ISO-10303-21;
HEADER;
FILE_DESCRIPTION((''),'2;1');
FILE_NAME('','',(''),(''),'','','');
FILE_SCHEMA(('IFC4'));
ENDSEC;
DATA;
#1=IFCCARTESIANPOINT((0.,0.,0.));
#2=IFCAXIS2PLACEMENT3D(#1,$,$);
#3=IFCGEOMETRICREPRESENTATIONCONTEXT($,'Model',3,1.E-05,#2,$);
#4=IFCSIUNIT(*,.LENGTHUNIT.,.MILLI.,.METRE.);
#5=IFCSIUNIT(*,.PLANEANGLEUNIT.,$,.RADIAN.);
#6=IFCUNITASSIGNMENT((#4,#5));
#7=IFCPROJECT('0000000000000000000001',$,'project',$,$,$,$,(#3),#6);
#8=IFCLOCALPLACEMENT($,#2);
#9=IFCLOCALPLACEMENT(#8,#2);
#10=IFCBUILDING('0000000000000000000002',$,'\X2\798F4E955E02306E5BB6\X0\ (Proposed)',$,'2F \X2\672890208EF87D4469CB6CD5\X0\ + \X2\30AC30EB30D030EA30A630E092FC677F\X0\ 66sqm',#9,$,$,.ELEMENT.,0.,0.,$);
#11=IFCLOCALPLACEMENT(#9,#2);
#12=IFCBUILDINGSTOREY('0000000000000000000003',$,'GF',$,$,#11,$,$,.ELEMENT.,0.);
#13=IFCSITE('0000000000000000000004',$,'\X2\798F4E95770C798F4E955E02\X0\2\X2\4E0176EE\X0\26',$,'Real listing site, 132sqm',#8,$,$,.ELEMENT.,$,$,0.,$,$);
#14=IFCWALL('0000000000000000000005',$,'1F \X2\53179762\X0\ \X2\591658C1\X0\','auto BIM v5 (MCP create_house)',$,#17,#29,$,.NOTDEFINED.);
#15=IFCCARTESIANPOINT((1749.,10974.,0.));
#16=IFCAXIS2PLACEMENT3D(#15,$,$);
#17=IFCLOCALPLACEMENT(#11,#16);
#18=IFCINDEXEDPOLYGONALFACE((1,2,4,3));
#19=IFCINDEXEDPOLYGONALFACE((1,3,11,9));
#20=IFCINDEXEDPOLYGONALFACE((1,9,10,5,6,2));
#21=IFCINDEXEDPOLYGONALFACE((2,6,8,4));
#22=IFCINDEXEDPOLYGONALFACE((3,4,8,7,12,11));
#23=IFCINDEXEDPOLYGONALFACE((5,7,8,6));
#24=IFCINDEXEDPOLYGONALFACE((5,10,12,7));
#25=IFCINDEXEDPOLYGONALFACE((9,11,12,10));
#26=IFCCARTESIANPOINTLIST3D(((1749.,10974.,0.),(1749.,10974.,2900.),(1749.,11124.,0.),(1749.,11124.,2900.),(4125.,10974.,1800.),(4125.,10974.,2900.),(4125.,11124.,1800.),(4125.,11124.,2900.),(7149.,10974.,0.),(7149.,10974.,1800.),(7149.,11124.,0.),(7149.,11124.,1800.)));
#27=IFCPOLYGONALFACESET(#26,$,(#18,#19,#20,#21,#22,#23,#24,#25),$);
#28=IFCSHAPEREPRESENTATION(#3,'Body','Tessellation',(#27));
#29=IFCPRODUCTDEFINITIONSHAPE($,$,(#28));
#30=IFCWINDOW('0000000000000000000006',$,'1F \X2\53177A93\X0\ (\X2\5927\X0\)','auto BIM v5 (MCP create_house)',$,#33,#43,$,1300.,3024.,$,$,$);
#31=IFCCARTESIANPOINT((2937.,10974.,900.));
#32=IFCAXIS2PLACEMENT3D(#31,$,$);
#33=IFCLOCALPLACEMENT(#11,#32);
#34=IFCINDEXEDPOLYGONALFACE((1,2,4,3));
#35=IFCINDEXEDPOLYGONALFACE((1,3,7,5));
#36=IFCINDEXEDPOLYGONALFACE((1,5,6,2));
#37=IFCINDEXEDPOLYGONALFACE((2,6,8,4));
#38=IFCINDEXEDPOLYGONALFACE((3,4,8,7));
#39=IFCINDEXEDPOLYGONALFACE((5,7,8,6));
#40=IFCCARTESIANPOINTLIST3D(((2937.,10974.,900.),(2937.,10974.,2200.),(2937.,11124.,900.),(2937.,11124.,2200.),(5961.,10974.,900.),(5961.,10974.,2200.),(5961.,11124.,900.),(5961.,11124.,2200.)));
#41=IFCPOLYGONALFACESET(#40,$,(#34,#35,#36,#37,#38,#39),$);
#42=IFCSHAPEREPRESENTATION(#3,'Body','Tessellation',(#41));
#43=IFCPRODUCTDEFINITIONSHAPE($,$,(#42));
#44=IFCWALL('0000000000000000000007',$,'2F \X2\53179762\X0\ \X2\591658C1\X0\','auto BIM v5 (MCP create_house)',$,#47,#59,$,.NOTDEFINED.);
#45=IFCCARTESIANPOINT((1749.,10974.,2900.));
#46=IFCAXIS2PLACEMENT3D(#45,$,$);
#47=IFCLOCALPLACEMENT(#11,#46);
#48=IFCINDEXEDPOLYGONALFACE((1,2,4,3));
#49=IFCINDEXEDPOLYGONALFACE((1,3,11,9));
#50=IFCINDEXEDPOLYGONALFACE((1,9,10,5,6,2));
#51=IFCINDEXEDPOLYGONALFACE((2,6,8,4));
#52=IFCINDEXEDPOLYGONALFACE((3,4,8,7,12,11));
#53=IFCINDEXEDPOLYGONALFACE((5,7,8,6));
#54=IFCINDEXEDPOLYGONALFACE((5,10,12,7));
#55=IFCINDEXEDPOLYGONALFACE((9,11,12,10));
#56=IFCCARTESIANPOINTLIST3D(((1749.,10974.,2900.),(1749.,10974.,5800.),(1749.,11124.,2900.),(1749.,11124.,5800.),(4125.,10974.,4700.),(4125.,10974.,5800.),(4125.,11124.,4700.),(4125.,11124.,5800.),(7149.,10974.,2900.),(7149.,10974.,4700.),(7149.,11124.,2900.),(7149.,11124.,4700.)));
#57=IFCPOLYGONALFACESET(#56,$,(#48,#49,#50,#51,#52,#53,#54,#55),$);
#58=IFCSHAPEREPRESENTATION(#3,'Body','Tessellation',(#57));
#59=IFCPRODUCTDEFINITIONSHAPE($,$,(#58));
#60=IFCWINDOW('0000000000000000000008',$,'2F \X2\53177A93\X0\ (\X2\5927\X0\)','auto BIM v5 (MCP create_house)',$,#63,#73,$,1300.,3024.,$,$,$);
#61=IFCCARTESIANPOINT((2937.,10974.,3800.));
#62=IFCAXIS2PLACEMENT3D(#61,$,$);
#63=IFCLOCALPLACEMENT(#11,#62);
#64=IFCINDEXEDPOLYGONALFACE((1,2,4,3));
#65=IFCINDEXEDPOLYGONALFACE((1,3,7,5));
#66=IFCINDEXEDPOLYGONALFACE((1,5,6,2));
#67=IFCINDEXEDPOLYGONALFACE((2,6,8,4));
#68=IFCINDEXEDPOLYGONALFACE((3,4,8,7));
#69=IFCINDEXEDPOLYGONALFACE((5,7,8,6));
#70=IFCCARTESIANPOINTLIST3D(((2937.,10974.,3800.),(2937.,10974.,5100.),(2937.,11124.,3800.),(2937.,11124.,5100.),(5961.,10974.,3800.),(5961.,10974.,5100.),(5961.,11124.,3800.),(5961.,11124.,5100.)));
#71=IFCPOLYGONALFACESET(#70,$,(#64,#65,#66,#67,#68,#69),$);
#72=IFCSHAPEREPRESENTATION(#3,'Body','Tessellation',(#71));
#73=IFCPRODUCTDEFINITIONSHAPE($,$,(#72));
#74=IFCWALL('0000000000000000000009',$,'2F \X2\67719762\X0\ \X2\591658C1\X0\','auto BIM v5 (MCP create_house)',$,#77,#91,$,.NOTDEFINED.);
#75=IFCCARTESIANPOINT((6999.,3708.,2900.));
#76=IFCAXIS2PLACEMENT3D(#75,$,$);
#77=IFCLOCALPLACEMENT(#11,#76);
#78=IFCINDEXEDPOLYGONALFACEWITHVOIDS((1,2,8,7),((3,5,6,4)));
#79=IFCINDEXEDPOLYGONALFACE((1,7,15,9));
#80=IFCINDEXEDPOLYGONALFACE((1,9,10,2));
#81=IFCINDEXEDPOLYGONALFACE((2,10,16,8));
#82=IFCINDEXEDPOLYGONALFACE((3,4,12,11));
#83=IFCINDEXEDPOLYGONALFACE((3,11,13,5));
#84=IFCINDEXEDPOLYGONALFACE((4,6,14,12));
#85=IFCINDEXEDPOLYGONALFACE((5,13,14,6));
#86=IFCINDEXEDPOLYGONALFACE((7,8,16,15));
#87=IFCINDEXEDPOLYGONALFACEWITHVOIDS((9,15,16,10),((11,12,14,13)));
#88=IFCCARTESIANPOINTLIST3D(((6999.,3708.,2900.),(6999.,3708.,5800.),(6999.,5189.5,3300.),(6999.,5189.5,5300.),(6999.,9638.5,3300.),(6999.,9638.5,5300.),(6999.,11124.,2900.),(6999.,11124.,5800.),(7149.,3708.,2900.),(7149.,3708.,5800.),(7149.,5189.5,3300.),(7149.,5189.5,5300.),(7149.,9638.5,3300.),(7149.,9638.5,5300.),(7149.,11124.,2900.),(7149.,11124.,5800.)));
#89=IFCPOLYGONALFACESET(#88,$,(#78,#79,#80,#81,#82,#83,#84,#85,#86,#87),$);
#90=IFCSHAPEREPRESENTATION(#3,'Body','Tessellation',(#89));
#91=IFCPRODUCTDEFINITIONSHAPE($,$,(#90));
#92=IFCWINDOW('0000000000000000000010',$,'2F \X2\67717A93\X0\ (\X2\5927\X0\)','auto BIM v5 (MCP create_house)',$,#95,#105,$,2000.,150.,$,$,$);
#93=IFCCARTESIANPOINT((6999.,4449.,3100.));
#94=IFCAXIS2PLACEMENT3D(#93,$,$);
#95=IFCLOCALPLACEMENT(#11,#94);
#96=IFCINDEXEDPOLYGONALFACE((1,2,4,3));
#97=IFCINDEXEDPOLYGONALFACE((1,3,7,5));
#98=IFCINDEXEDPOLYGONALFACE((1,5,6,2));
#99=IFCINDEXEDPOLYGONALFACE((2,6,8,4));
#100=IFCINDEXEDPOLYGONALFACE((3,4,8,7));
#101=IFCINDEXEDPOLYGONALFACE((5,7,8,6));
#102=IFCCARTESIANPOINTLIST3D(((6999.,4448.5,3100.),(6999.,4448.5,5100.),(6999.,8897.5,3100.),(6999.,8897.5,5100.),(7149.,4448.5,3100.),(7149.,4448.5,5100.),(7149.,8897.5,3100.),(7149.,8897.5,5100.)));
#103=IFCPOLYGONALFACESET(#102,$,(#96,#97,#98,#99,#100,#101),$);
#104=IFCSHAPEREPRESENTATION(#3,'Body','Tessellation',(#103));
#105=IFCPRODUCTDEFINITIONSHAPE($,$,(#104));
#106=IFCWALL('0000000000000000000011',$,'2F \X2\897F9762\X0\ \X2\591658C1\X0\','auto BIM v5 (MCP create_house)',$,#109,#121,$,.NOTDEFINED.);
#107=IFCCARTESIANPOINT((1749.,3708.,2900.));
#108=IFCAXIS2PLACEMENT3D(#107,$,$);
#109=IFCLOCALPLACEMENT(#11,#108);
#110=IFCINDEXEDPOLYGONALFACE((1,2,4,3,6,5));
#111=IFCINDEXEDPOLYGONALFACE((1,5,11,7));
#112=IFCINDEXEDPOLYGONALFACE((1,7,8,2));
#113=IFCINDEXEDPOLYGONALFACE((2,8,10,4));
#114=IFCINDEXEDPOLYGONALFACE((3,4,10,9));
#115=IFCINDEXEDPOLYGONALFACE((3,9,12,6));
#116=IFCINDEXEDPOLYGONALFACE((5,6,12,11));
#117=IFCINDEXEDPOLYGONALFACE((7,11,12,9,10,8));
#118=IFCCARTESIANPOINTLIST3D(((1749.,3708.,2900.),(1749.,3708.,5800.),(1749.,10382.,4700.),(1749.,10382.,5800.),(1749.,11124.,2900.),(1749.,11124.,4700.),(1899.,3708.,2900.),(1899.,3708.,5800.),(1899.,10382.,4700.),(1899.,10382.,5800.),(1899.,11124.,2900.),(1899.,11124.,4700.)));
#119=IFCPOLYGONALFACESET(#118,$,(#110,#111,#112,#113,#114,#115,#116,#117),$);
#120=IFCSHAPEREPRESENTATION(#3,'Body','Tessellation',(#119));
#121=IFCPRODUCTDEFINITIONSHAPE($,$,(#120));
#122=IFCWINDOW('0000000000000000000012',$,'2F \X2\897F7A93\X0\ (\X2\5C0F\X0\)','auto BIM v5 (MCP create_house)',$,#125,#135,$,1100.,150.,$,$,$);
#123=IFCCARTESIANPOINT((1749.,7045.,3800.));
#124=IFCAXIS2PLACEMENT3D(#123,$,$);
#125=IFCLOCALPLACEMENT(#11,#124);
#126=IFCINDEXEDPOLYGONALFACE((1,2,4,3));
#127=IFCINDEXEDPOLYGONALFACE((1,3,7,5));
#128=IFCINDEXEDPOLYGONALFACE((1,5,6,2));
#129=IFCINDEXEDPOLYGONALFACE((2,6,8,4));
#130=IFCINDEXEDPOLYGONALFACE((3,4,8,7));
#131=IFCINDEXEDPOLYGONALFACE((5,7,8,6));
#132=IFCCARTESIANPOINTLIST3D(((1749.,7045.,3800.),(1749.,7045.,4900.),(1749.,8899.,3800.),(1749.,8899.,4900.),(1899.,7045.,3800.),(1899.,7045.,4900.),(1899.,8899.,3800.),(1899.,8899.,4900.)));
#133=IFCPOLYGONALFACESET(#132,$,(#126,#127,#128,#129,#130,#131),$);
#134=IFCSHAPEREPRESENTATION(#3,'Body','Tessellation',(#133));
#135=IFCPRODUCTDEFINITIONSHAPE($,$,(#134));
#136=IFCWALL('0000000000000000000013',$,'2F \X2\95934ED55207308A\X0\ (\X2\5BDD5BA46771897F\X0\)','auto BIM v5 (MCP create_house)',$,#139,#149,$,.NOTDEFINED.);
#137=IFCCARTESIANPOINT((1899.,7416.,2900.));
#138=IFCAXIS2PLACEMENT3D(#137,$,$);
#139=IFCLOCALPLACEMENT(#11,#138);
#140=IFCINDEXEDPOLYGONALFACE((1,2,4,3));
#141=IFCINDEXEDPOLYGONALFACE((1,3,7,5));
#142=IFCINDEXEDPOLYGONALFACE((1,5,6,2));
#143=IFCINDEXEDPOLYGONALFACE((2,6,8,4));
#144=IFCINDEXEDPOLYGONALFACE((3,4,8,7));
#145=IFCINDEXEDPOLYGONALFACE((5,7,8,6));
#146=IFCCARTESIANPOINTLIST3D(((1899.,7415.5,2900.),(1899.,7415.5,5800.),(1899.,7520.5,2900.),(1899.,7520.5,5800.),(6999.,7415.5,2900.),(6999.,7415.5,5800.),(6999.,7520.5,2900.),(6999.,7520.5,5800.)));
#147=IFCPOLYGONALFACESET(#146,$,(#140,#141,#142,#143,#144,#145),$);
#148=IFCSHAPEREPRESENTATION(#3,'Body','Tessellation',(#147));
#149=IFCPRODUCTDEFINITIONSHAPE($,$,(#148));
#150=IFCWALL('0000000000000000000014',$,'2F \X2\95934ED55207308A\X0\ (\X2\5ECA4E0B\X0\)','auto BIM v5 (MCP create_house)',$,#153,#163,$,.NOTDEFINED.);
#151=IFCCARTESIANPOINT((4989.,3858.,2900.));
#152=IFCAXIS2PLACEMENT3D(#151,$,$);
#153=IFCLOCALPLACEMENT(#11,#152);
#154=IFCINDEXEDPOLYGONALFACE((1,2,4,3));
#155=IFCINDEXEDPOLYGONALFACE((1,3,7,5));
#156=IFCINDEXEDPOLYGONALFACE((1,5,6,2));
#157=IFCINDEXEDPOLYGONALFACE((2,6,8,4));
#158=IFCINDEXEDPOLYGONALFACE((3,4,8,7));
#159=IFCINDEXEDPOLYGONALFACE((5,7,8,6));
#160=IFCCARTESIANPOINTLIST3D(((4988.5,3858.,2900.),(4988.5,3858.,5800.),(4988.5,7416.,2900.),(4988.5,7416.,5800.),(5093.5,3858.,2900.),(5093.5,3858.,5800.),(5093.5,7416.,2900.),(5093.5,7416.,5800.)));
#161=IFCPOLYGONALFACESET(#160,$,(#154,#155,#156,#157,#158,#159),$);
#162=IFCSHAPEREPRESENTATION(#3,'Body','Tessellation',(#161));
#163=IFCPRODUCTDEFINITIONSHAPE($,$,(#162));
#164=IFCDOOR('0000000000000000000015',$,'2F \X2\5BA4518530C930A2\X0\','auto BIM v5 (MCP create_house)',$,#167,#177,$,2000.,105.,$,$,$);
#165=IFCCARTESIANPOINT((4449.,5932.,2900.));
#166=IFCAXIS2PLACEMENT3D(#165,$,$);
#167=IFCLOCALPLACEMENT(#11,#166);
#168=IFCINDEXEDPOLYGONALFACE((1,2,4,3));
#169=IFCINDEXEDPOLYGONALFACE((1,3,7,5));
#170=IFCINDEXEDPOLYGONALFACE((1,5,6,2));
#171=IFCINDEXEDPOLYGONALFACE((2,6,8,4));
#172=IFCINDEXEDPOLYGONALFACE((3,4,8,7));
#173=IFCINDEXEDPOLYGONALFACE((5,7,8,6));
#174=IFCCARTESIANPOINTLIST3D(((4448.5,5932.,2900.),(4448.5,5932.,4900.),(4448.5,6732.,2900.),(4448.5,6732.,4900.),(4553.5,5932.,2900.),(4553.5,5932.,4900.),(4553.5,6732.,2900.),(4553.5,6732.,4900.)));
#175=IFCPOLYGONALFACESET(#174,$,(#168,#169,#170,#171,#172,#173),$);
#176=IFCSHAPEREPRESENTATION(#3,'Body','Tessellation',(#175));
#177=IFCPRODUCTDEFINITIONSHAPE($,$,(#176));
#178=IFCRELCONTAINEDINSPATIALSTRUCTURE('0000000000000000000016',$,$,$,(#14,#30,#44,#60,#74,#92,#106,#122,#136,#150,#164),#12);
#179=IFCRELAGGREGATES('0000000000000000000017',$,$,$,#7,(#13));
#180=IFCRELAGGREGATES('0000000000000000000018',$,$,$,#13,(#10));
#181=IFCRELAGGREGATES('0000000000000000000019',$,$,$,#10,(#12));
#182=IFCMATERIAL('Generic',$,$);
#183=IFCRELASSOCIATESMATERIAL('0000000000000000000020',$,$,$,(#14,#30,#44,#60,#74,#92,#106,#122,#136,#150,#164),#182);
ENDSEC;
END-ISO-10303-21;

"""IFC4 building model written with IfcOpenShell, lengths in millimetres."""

from ifc_helpers import new_model, si_unit, frame, frame_2d, origin, place, context, project, spatial, rectangle, extrude, material, element, fill, save


model = new_model("IFC4")

# Units and contexts
model_context = context("Model", 3, precision=1e-05, world=origin())
ifc_project = project(units=[si_unit("LENGTHUNIT", "METRE", prefix="MILLI"), si_unit("PLANEANGLEUNIT", "RADIAN")], contexts=[model_context])

# Site, building, storey
site_placement = place(None, origin())
site = spatial("IfcSite", under=ifc_project, at=site_placement, Name="福井県福井市2丁目26", ObjectType="Real listing site, 132sqm", CompositionType="ELEMENT", RefElevation=0.0)
building_placement = place(site_placement, origin())
building = spatial("IfcBuilding", under=site, at=building_placement, Name="福井市の家 (Proposed)", ObjectType="2F 木造軸組構法 + ガルバリウム鋼板 66sqm", CompositionType="ELEMENT", ElevationOfRefHeight=0.0, ElevationOfTerrain=0.0)
storey_placement = place(building_placement, origin())
storey = spatial("IfcBuildingStorey", under=building, at=storey_placement, Name="GF", CompositionType="ELEMENT", Elevation=0.0)

# Wall, opening, window
ifc_material = material(Name="Generic")
wall_1_placement = place(storey_placement, frame((1749.0, 10974.0, 0.0)))
wall_1 = element("IfcWall", 1, at=wall_1_placement, inside=storey, material=ifc_material, Name="1F 北面 外壁", Description="auto BIM v5 (MCP create_house)", PredefinedType="NOTDEFINED", context=model_context, shape_type="SweptSolid", body=[
    extrude(rectangle(XDim=5400.0, YDim=150.0, at=frame_2d((2700.0, 75.0))), frame((1749.0, 10974.0, 0.0)), (0.0, 0.0, 1.0), 2900.0),
])
opening_1_placement = place(storey_placement, frame((2937.0, 10974.0, 900.0)))
opening_1 = element("IfcOpeningElement", 2, at=opening_1_placement, cuts=wall_1, PredefinedType="NOTDEFINED", context=model_context, shape_type="SweptSolid", body=[
    extrude(rectangle(XDim=3024.0, YDim=150.0, at=frame_2d((1512.0, 75.0))), frame((2937.0, 10974.0, 900.0)), (0.0, 0.0, 1.0), 1300.0),
])
window_1_placement = place(storey_placement, frame((2937.0, 10974.0, 900.0)))
window_1 = element("IfcWindow", 3, at=window_1_placement, inside=storey, material=ifc_material, Name="1F 北窓 (大)", Description="auto BIM v5 (MCP create_house)", OverallHeight=1300.0, OverallWidth=3024.0, context=model_context, shape_type="SweptSolid", body=[
    extrude(rectangle(XDim=3024.0, YDim=150.0, at=frame_2d((1512.0, 75.0))), frame((2937.0, 10974.0, 900.0)), (0.0, 0.0, 1.0), 1300.0),
])
fill(opening_1, window_1)

# Walls, openings, windows
wall_2_placement = place(storey_placement, frame((1749.0, 10974.0, 2900.0)))
wall_2 = element("IfcWall", 4, at=wall_2_placement, inside=storey, material=ifc_material, Name="2F 北面 外壁", Description="auto BIM v5 (MCP create_house)", PredefinedType="NOTDEFINED", context=model_context, shape_type="SweptSolid", body=[
    extrude(rectangle(XDim=5400.0, YDim=150.0, at=frame_2d((2700.0, 75.0))), frame((1749.0, 10974.0, 2900.0)), (0.0, 0.0, 1.0), 2900.0),
])
opening_2_placement = place(storey_placement, frame((2937.0, 10974.0, 3800.0)))
opening_2 = element("IfcOpeningElement", 5, at=opening_2_placement, cuts=wall_2, PredefinedType="NOTDEFINED", context=model_context, shape_type="SweptSolid", body=[
    extrude(rectangle(XDim=3024.0, YDim=150.0, at=frame_2d((1512.0, 75.0))), frame((2937.0, 10974.0, 3800.0)), (0.0, 0.0, 1.0), 1300.0),
])
window_2_placement = place(storey_placement, frame((2937.0, 10974.0, 3800.0)))
window_2 = element("IfcWindow", 6, at=window_2_placement, inside=storey, material=ifc_material, Name="2F 北窓 (大)", Description="auto BIM v5 (MCP create_house)", OverallHeight=1300.0, OverallWidth=3024.0, context=model_context, shape_type="SweptSolid", body=[
    extrude(rectangle(XDim=3024.0, YDim=150.0, at=frame_2d((1512.0, 75.0))), frame((2937.0, 10974.0, 3800.0)), (0.0, 0.0, 1.0), 1300.0),
])
fill(opening_2, window_2)
wall_3_placement = place(storey_placement, frame((6999.0, 3708.0, 2900.0)))
wall_3 = element("IfcWall", 7, at=wall_3_placement, inside=storey, material=ifc_material, Name="2F 東面 外壁", Description="auto BIM v5 (MCP create_house)", PredefinedType="NOTDEFINED", context=model_context, shape_type="SweptSolid", body=[
    extrude(rectangle(XDim=150.0, YDim=7416.0, at=frame_2d((75.0, 3708.0))), frame((6999.0, 3708.0, 2900.0)), (0.0, 0.0, 1.0), 2900.0),
])
opening_3_placement = place(storey_placement, frame((6999.0, 4449.0, 3100.0)))
opening_3 = element("IfcOpeningElement", 8, at=opening_3_placement, cuts=wall_3, PredefinedType="NOTDEFINED", context=model_context, shape_type="SweptSolid", body=[
    extrude(rectangle(XDim=150.0, YDim=4449.0, at=frame_2d((75.0, 2224.0))), frame((6999.0, 4449.0, 3100.0)), (0.0, 0.0, 1.0), 2000.0),
])
window_3_placement = place(storey_placement, frame((6999.0, 4449.0, 3100.0)))
window_3 = element("IfcWindow", 9, at=window_3_placement, inside=storey, material=ifc_material, Name="2F 東窓 (大)", Description="auto BIM v5 (MCP create_house)", OverallHeight=2000.0, OverallWidth=150.0, context=model_context, shape_type="SweptSolid", body=[
    extrude(rectangle(XDim=150.0, YDim=4449.0, at=frame_2d((75.0, 2224.0))), frame((6999.0, 4449.0, 3100.0)), (0.0, 0.0, 1.0), 2000.0),
])
fill(opening_3, window_3)
wall_4_placement = place(storey_placement, frame((1749.0, 3708.0, 2900.0)))
wall_4 = element("IfcWall", 10, at=wall_4_placement, inside=storey, material=ifc_material, Name="2F 西面 外壁", Description="auto BIM v5 (MCP create_house)", PredefinedType="NOTDEFINED", context=model_context, shape_type="SweptSolid", body=[
    extrude(rectangle(XDim=150.0, YDim=7416.0, at=frame_2d((75.0, 3708.0))), frame((1749.0, 3708.0, 2900.0)), (0.0, 0.0, 1.0), 2900.0),
])
opening_4_placement = place(storey_placement, frame((1749.0, 7045.0, 3800.0)))
opening_4 = element("IfcOpeningElement", 11, at=opening_4_placement, cuts=wall_4, PredefinedType="NOTDEFINED", context=model_context, shape_type="SweptSolid", body=[
    extrude(rectangle(XDim=150.0, YDim=1854.0, at=frame_2d((75.0, 927.0))), frame((1749.0, 7045.0, 3800.0)), (0.0, 0.0, 1.0), 1100.0),
])
window_4_placement = place(storey_placement, frame((1749.0, 7045.0, 3800.0)))
window_4 = element("IfcWindow", 12, at=window_4_placement, inside=storey, material=ifc_material, Name="2F 西窓 (小)", Description="auto BIM v5 (MCP create_house)", OverallHeight=1100.0, OverallWidth=150.0, context=model_context, shape_type="SweptSolid", body=[
    extrude(rectangle(XDim=150.0, YDim=1854.0, at=frame_2d((75.0, 927.0))), frame((1749.0, 7045.0, 3800.0)), (0.0, 0.0, 1.0), 1100.0),
])
fill(opening_4, window_4)

# Walls
wall_5_placement = place(storey_placement, frame((1899.0, 7416.0, 2900.0)))
element("IfcWall", 13, at=wall_5_placement, inside=storey, material=ifc_material, Name="2F 間仕切り (寝室東西)", Description="auto BIM v5 (MCP create_house)", PredefinedType="NOTDEFINED", context=model_context, shape_type="SweptSolid", body=[
    extrude(rectangle(XDim=5100.0, YDim=105.0, at=frame_2d((2550.0, 52.0))), frame((1899.0, 7416.0, 2900.0)), (0.0, 0.0, 1.0), 2900.0),
])
wall_6_placement = place(storey_placement, frame((4989.0, 3858.0, 2900.0)))
element("IfcWall", 14, at=wall_6_placement, inside=storey, material=ifc_material, Name="2F 間仕切り (廊下)", Description="auto BIM v5 (MCP create_house)", PredefinedType="NOTDEFINED", context=model_context, shape_type="SweptSolid", body=[
    extrude(rectangle(XDim=105.0, YDim=3558.0, at=frame_2d((52.0, 1779.0))), frame((4989.0, 3858.0, 2900.0)), (0.0, 0.0, 1.0), 2900.0),
])

# Door
door_placement = place(storey_placement, frame((4449.0, 5932.0, 2900.0)))
element("IfcDoor", 15, at=door_placement, inside=storey, material=ifc_material, Name="2F 室内ドア", Description="auto BIM v5 (MCP create_house)", OverallHeight=2000.0, OverallWidth=105.0, context=model_context, shape_type="SweptSolid", body=[
    extrude(rectangle(XDim=105.0, YDim=800.0, at=frame_2d((52.0, 400.0))), frame((4449.0, 5932.0, 2900.0)), (0.0, 0.0, 1.0), 2000.0),
])

save(model, "model.ifc")
